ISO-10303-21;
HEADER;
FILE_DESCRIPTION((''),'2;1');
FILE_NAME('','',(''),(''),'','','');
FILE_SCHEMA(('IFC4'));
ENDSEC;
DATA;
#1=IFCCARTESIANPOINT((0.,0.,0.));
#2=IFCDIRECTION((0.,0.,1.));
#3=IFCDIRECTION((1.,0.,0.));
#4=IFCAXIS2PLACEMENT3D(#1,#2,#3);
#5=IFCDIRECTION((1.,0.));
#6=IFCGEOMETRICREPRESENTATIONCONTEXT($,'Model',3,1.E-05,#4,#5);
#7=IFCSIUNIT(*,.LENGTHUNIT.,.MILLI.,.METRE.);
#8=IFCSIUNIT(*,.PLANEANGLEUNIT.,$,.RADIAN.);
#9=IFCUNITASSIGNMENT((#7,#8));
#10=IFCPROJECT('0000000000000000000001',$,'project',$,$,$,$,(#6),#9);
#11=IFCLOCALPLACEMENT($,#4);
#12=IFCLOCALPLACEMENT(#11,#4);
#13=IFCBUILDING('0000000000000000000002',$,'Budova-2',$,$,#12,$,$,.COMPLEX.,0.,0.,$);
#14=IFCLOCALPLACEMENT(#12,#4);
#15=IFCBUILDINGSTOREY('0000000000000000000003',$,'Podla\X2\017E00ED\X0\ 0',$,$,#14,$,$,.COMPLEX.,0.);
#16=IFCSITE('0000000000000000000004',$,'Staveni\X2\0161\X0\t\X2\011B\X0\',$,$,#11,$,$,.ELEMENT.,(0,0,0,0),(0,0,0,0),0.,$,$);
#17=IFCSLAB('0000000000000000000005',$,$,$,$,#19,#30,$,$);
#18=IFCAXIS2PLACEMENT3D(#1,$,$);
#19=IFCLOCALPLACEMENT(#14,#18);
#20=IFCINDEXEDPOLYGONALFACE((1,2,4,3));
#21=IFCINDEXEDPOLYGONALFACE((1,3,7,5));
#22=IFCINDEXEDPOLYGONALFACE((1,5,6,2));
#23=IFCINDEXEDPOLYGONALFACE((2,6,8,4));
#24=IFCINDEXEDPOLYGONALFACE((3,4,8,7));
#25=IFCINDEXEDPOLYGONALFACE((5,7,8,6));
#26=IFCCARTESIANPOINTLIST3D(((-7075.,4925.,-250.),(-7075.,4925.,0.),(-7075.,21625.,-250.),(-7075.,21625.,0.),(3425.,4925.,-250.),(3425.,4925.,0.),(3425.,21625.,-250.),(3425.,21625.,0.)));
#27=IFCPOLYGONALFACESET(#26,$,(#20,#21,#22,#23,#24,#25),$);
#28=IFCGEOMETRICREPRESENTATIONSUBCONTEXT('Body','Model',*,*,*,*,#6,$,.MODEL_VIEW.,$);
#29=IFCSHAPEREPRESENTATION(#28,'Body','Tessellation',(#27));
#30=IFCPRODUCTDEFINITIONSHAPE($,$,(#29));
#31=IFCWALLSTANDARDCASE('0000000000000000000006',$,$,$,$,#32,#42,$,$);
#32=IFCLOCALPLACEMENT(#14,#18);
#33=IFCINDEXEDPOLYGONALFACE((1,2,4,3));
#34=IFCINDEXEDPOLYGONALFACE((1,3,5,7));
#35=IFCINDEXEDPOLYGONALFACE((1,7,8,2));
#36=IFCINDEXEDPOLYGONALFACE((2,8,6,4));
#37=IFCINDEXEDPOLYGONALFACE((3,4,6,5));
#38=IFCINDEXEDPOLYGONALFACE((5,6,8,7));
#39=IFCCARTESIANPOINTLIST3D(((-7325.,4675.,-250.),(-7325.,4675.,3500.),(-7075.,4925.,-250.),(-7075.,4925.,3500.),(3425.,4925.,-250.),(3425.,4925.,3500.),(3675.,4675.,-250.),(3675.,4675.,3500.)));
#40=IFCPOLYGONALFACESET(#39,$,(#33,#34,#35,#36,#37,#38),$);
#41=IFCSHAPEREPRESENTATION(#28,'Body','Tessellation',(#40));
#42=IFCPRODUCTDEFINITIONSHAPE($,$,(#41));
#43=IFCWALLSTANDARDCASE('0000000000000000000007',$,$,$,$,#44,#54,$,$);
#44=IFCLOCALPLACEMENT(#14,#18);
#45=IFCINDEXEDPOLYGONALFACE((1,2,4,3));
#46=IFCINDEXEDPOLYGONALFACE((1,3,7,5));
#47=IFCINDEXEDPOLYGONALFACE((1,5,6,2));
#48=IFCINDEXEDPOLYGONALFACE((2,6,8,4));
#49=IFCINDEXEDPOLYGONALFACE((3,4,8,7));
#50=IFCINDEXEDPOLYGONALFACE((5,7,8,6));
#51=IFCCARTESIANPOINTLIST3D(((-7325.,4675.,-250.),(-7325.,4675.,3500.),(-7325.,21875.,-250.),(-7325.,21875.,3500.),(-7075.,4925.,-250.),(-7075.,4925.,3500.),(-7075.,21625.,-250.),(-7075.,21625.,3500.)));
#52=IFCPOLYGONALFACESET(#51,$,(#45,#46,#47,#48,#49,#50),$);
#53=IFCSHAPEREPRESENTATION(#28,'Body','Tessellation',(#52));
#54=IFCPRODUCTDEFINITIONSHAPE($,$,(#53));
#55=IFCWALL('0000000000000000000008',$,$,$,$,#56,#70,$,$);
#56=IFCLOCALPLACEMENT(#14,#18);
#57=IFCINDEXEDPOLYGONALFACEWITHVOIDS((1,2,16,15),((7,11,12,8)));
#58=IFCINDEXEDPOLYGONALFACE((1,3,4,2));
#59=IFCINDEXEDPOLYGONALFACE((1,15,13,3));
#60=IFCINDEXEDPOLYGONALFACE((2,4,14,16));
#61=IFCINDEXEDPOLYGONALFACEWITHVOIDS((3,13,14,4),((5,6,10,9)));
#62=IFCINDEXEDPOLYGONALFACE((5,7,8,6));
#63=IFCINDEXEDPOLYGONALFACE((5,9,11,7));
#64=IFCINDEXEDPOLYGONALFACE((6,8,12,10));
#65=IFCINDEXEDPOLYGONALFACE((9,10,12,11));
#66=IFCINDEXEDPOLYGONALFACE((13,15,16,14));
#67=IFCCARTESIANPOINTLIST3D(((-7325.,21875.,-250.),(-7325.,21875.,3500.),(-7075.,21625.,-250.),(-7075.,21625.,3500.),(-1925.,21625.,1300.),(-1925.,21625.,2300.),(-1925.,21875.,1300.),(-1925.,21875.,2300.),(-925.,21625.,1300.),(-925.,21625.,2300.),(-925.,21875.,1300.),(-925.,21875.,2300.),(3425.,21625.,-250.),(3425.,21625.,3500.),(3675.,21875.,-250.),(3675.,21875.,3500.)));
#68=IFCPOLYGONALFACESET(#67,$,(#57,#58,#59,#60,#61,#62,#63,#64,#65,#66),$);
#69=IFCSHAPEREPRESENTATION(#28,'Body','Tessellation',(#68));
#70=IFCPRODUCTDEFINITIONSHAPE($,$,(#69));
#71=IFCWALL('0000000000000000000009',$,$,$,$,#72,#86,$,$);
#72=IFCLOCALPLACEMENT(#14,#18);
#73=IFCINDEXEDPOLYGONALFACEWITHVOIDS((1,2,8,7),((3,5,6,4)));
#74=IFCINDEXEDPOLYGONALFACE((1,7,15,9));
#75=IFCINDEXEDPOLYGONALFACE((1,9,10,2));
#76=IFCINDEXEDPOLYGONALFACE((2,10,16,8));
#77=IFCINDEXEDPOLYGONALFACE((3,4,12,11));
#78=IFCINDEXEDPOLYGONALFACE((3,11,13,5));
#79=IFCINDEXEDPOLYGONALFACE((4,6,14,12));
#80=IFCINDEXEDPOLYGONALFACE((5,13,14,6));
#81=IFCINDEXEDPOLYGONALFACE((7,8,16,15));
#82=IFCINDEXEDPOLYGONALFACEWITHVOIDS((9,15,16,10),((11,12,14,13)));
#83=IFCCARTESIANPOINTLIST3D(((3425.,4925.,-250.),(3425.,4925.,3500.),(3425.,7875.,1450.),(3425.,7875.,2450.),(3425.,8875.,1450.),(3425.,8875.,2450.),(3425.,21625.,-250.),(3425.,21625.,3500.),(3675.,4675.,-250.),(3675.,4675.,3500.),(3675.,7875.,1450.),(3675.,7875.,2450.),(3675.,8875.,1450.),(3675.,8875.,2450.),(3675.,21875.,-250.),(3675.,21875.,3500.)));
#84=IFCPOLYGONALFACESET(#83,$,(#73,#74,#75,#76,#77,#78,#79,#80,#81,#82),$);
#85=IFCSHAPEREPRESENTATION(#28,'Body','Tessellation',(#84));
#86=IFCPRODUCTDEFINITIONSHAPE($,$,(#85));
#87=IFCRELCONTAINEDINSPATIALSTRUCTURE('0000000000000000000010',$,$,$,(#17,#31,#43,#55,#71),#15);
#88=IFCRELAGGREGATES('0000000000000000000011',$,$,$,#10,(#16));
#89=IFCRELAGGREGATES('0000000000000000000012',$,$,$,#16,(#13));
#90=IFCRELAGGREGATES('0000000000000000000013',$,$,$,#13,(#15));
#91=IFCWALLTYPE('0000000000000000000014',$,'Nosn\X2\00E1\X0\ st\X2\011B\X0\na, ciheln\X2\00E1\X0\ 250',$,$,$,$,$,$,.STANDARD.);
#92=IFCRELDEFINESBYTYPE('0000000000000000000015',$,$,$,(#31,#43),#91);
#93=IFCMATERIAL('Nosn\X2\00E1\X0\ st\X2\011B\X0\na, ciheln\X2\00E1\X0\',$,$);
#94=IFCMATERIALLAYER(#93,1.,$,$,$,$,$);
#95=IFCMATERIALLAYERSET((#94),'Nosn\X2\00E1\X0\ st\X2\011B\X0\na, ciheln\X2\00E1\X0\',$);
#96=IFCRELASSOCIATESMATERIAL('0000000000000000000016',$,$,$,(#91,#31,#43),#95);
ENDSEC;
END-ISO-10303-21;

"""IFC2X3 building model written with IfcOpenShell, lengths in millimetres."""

from ifc_helpers import new_model, si_unit, direction, frame, frame_2d, origin_with_axes, place, context, subcontext, project, spatial, polyline, rectangle, outline, extrude, material, layer, layer_set, layer_usage, type_object, element, save


model = new_model("IFC2X3")

# Units and contexts
model_context = context("Model", 3, precision=1e-05, world=origin_with_axes(), true_north=direction((1.0, 0.0)))
body_context = subcontext(model_context, "Body", "Model", "MODEL_VIEW")
ifc_project = project(units=[si_unit("LENGTHUNIT", "METRE", prefix="MILLI"), si_unit("PLANEANGLEUNIT", "RADIAN")], contexts=[model_context])

# Site, building, storey
site_placement = place(None, origin_with_axes())
site = spatial("IfcSite", under=ifc_project, at=site_placement, Name="Staveniště", CompositionType="ELEMENT", RefLatitude=(0, 0, 0, 0), RefLongitude=(0, 0, 0, 0), RefElevation=0.0)
building_placement = place(site_placement, origin_with_axes())
building = spatial("IfcBuilding", under=site, at=building_placement, Name="Budova-2", CompositionType="COMPLEX", ElevationOfRefHeight=0.0, ElevationOfTerrain=0.0)
storey_placement = place(building_placement, origin_with_axes())
storey = spatial("IfcBuildingStorey", under=building, at=storey_placement, Name="Podlaží 0", CompositionType="COMPLEX", Elevation=0.0)

# Slab
slab_placement = place(storey_placement, frame((-7075.0, 21625.0, -250.0), z_axis=(0.0, 0.0, 1.0), x_axis=(0.0, -1.0, 0.0)))
element("IfcSlab", 1, at=slab_placement, inside=storey, context=body_context, shape_type="SweptSolid", body=[
    extrude(rectangle(XDim=16700.0, YDim=10500.0, at=frame_2d((0.0, 0.0), x_axis=(-1.0, 0.0))), frame((8350.0, 5250.0, 0.0), z_axis=(0.0, 0.0, 1.0), x_axis=(1.0, 0.0, 0.0)), (0.0, 0.0, 1.0), 250.0),
])

# Walls
ifc_material = material(Name="Nosná stěna, cihelná")
ifc_layer = layer(ifc_material, 1.0)
ifc_layer_set = layer_set([ifc_layer], Name="Nosná stěna, cihelná")
ifc_layer_usage_1 = layer_usage(ifc_layer_set, "AXIS2", "POSITIVE", 0.0)
wall_type = type_object("IfcWallType", Name="Nosná stěna, cihelná 250", PredefinedType="STANDARD", material=ifc_layer_set)
wall_1_placement = place(storey_placement, frame((-7325.0, 4675.0, -250.0), z_axis=(0.0, 0.0, 1.0), x_axis=(1.0, 0.0, 0.0)))
element("IfcWallStandardCase", 2, at=wall_1_placement, inside=storey, type_object=wall_type, material=ifc_layer_usage_1, context=body_context, shape_type="SweptSolid", body=[
    extrude(outline(polyline([(5250.0, 125.0), (5500.0, -125.0), (-5500.0, -125.0), (-5250.0, 125.0), (5250.0, 125.0)])), frame((5500.0, 125.0, 0.0), z_axis=(0.0, 0.0, 1.0), x_axis=(1.0, 0.0, 0.0)), (0.0, 0.0, 1.0), 3750.0),
])
ifc_layer_usage_2 = layer_usage(ifc_layer_set, "AXIS2", "POSITIVE", 0.0)
wall_2_placement = place(storey_placement, frame((-7325.0, 21875.0, -250.0), z_axis=(0.0, 0.0, 1.0), x_axis=(0.0, -1.0, 0.0)))
element("IfcWallStandardCase", 3, at=wall_2_placement, inside=storey, type_object=wall_type, material=ifc_layer_usage_2, context=body_context, shape_type="SweptSolid", body=[
    extrude(outline(polyline([(-8350.0, 125.0), (8350.0, 125.0), (8600.0, -125.0), (-8600.0, -125.0), (-8350.0, 125.0)])), frame((8600.0, 125.0, 0.0), z_axis=(0.0, 0.0, 1.0), x_axis=(1.0, 0.0, 0.0)), (0.0, 0.0, 1.0), 3750.0),
])

# Walls, openings
wall_3_placement = place(storey_placement, origin_with_axes())
wall_3 = element("IfcWall", 4, at=wall_3_placement, inside=storey, context=body_context, shape_type="SweptSolid", body=[
    extrude(outline(polyline([(5500.0, 125.0), (5250.0, -125.0), (-5250.0, -125.0), (-5500.0, 125.0), (5500.0, 125.0)])), frame((-1825.0, 21750.0, -250.0), z_axis=(0.0, 0.0, 1.0), x_axis=(1.0, 0.0, 0.0)), (0.0, 0.0, 1.0), 3750.0),
])
opening_1_placement = place(wall_3_placement, frame((-925.0, 21875.0, 1300.0), z_axis=(0.0, 0.0, 1.0), x_axis=(-1.0, 0.0, 0.0)))
element("IfcOpeningElement", 5, at=opening_1_placement, cuts=wall_3, ObjectType="Opening", context=body_context, shape_type="SweptSolid", body=[
    extrude(outline(polyline([(-500.0, -500.0), (-500.0, 500.0), (500.0, 500.0), (500.0, -500.0), (-500.0, -500.0)])), frame((500.0, 0.0, 500.0), z_axis=(0.0, 1.0, 0.0), x_axis=(1.0, 0.0, 0.0)), (0.0, 0.0, 1.0), 1090.0),
])
wall_4_placement = place(storey_placement, origin_with_axes())
wall_4 = element("IfcWall", 6, at=wall_4_placement, inside=storey, context=body_context, shape_type="SweptSolid", body=[
    extrude(outline(polyline([(125.0, 8600.0), (125.0, -8600.0), (-125.0, -8350.0), (-125.0, 8350.0), (125.0, 8600.0)])), frame((3550.0, 13275.0, -250.0), z_axis=(0.0, 0.0, 1.0), x_axis=(1.0, 0.0, 0.0)), (0.0, 0.0, 1.0), 3750.0),
])
opening_2_placement = place(wall_4_placement, frame((3675.0, 7875.0, 1450.0), z_axis=(0.0, 0.0, 1.0), x_axis=(0.0, 1.0, 0.0)))
element("IfcOpeningElement", 7, at=opening_2_placement, cuts=wall_4, ObjectType="Opening", context=body_context, shape_type="SweptSolid", body=[
    extrude(outline(polyline([(-500.0, -500.0), (-500.0, 500.0), (500.0, 500.0), (500.0, -500.0), (-500.0, -500.0)])), frame((500.0, 0.0, 500.0), z_axis=(0.0, 1.0, 0.0), x_axis=(1.0, 0.0, 0.0)), (0.0, 0.0, 1.0), 1090.0),
])

save(model, "model.ifc")
